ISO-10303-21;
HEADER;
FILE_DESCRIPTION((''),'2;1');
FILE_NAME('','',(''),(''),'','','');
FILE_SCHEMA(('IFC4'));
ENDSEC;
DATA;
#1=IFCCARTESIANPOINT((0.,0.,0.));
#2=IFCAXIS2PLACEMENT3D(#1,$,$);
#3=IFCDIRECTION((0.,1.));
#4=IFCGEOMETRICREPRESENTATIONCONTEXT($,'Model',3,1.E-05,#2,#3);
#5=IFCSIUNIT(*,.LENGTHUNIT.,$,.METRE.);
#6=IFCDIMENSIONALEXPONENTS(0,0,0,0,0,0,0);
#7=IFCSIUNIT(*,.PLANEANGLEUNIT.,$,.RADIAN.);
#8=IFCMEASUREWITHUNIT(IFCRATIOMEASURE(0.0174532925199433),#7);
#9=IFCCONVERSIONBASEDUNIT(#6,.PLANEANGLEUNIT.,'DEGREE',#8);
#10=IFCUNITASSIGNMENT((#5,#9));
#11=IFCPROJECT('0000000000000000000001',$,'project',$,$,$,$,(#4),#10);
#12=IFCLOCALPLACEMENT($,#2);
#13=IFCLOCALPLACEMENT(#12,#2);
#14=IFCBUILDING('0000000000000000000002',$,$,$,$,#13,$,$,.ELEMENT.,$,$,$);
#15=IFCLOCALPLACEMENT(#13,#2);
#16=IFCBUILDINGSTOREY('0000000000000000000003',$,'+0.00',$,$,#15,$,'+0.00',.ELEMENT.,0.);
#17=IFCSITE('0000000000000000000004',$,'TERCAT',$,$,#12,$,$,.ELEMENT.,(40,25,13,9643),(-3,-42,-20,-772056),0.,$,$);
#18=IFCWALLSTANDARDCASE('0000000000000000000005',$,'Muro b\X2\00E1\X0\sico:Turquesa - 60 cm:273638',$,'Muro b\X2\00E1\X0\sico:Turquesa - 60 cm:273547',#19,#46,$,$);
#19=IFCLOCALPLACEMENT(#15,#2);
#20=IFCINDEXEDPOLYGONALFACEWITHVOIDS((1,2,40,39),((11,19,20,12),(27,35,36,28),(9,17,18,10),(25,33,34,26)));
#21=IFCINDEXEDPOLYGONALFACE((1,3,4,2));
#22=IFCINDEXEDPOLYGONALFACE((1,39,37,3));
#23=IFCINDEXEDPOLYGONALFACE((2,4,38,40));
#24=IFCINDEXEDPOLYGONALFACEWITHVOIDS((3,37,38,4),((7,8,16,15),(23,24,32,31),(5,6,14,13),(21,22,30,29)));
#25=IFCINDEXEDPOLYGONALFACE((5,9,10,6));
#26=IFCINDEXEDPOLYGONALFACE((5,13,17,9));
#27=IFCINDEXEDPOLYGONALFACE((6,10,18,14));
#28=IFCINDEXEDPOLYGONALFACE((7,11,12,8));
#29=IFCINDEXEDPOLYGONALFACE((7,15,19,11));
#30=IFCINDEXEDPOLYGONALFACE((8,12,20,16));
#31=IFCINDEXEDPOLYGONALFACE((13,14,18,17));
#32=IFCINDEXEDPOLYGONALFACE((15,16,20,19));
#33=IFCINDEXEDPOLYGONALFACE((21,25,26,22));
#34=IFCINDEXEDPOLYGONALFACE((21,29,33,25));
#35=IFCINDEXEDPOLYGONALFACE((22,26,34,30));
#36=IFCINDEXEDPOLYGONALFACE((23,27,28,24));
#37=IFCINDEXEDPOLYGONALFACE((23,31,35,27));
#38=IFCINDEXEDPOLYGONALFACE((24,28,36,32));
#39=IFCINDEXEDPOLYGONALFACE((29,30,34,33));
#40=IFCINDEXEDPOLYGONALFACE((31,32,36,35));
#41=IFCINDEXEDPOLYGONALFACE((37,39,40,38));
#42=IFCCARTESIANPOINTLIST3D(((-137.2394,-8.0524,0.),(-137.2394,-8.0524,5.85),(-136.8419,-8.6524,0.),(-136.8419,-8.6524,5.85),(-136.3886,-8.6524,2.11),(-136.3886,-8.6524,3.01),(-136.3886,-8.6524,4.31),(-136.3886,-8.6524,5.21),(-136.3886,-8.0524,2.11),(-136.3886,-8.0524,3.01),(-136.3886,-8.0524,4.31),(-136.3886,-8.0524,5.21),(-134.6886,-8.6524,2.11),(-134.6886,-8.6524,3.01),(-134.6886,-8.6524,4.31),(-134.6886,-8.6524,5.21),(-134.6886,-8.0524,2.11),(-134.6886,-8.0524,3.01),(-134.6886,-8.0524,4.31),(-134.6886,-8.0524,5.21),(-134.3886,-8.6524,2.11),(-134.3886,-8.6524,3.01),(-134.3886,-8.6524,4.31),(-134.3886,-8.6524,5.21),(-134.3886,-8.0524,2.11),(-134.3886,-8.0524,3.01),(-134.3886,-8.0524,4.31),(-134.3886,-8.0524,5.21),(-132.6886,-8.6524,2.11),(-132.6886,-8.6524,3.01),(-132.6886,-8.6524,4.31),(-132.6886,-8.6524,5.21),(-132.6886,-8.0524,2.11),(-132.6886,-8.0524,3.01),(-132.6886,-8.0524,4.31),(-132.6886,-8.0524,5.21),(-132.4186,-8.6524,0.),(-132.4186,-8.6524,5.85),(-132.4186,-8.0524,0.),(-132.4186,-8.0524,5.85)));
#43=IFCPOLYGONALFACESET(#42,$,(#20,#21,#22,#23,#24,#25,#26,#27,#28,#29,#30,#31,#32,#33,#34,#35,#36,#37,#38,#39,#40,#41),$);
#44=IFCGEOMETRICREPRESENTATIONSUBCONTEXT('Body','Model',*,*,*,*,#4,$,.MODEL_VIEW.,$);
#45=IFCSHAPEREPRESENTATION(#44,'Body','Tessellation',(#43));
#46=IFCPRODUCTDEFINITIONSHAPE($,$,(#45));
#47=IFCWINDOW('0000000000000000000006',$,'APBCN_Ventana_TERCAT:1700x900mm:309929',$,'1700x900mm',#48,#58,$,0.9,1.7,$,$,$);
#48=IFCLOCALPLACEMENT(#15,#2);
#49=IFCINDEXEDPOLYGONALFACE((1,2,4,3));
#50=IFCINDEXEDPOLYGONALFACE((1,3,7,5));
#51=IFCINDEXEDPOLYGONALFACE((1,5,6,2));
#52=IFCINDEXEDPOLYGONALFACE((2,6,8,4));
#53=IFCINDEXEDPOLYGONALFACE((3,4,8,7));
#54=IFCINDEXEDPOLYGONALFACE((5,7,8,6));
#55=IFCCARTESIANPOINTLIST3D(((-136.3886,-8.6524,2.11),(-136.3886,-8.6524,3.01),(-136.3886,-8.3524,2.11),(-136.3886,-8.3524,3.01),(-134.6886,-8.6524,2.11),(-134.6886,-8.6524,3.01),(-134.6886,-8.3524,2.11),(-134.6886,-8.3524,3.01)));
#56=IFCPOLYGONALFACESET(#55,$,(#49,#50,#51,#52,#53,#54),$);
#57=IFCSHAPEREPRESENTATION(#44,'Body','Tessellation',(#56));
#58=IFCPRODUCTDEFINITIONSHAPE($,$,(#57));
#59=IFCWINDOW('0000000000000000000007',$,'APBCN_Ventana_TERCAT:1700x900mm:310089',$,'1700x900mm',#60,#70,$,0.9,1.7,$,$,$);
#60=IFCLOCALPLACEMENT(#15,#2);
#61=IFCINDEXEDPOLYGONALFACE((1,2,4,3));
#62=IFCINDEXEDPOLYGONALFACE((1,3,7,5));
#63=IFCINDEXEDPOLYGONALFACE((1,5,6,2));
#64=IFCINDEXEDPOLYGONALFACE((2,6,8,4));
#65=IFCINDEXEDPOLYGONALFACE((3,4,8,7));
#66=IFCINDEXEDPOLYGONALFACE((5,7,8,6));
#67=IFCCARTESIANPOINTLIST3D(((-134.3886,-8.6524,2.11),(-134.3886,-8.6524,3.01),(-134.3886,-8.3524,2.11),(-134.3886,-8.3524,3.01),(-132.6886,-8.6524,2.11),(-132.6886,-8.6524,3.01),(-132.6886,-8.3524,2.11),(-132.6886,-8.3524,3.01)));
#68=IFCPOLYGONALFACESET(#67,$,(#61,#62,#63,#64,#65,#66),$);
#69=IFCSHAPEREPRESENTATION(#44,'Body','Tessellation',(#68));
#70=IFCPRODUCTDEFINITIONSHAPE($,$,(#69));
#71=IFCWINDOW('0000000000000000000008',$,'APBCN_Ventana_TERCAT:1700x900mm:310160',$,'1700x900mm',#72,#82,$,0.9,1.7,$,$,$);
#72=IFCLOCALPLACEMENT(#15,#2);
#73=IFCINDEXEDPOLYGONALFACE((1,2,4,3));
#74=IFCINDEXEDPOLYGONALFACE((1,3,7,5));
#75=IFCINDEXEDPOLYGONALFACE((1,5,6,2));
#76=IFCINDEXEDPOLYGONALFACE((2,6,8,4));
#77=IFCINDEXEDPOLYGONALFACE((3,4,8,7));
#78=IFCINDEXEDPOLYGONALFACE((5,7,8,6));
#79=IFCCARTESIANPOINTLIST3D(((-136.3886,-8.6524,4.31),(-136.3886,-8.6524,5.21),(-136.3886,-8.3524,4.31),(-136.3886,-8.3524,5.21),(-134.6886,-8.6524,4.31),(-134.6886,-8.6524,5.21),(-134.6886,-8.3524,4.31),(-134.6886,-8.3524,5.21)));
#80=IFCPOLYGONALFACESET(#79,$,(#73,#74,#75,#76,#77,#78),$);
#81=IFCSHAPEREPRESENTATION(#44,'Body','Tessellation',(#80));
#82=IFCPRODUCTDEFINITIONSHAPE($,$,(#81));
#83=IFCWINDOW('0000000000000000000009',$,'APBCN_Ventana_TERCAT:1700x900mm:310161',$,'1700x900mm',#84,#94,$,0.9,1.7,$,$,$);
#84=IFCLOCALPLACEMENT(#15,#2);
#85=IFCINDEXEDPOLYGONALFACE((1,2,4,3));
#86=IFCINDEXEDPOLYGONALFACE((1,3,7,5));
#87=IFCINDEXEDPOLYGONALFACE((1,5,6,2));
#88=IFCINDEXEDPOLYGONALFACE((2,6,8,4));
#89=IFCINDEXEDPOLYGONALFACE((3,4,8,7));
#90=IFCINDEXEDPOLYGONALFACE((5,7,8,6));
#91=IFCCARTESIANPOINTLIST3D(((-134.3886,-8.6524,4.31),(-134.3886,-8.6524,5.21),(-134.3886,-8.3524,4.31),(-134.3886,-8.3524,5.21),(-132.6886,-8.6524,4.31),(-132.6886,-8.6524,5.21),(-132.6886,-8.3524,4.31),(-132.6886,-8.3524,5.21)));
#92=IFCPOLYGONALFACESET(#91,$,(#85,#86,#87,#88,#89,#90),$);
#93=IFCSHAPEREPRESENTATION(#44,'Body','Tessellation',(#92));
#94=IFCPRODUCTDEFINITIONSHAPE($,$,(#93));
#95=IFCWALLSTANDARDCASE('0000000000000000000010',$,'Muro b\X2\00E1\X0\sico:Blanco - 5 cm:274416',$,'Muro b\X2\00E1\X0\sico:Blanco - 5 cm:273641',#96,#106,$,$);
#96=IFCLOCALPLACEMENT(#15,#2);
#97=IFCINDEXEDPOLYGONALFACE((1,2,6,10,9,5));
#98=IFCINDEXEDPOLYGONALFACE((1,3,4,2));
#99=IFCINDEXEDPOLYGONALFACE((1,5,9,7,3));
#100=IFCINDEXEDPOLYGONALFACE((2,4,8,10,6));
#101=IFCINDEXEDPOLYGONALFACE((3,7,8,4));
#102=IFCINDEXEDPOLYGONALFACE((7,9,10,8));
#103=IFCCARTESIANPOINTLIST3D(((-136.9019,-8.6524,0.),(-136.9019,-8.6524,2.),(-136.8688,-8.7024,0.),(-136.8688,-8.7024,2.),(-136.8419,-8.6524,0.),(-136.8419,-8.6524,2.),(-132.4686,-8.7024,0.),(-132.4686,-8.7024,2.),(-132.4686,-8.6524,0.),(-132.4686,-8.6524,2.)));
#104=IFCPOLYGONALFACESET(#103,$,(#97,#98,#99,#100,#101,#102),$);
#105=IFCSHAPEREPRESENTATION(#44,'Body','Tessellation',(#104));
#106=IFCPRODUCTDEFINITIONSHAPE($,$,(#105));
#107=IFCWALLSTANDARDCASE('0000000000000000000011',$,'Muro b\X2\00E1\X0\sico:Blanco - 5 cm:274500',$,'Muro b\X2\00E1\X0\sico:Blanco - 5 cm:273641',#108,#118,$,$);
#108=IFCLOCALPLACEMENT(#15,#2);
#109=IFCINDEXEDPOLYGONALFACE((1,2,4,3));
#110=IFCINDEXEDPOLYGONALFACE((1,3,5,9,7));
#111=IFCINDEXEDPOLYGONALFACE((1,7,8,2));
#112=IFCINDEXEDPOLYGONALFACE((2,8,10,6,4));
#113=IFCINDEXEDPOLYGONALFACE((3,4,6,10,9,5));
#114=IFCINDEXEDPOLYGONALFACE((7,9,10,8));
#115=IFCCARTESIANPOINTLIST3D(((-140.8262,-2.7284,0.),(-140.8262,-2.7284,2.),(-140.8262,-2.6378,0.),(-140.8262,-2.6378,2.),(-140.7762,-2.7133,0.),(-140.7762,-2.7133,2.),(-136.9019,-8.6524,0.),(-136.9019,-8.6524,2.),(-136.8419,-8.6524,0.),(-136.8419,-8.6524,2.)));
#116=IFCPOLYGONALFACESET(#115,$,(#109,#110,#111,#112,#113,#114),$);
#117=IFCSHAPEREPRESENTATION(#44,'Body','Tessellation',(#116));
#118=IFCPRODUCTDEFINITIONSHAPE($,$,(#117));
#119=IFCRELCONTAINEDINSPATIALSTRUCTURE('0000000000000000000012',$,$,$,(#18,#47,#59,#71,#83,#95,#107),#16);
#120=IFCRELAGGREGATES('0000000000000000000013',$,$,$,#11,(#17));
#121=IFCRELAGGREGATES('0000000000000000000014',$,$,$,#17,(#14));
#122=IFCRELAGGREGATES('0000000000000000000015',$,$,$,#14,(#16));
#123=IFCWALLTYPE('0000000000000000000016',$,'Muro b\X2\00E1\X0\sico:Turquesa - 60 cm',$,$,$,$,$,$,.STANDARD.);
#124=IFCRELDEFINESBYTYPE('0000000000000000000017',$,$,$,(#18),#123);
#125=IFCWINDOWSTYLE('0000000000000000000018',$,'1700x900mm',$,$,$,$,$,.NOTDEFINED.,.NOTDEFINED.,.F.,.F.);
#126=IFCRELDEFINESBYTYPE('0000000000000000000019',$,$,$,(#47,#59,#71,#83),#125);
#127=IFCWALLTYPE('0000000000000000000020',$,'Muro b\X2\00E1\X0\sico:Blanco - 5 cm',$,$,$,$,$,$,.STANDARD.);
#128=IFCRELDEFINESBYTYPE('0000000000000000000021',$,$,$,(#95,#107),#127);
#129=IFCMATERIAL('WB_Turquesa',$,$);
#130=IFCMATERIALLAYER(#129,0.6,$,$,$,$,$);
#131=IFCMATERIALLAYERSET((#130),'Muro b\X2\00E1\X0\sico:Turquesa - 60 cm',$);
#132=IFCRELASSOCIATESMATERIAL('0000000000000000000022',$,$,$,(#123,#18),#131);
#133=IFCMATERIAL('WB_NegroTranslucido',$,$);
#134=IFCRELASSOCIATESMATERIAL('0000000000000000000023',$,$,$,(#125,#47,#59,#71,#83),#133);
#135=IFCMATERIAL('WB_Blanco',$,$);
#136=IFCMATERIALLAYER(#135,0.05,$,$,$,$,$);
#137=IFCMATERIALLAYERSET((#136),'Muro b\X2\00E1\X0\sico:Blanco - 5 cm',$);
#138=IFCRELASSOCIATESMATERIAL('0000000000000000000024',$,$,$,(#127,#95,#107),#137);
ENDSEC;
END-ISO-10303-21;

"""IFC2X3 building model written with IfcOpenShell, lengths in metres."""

from ifc_helpers import new_model, entity, si_unit, converted_unit, direction, frame, frame_2d, origin, place, context, subcontext, project, spatial, polyline, rectangle, outline, extrude, clip, bounded_halfspace, source, transform, mapped, material, layer, layer_set, layer_usage, type_object, type_shapes, element, fill, save


model = new_model("IFC2X3")

# Units and contexts
model_context = context("Model", 3, precision=1e-05, world=origin(), true_north=direction((0.0, 1.0)))
body_context = subcontext(model_context, "Body", "Model", "MODEL_VIEW")
ifc_project = project(units=[si_unit("LENGTHUNIT", "METRE"), converted_unit("PLANEANGLEUNIT", "DEGREE", entity("IfcRatioMeasure", 0.0174532925199433), si_unit("PLANEANGLEUNIT", "RADIAN"), dimensions=[0, 0, 0, 0, 0, 0, 0])], contexts=[model_context])

# Site, building, storey
site_placement = place(None, origin())
site = spatial("IfcSite", under=ifc_project, at=site_placement, Name="TERCAT", CompositionType="ELEMENT", RefLatitude=(40, 25, 13, 9643), RefLongitude=(-3, -42, -20, -772056), RefElevation=0.0)
building_placement = place(site_placement, origin())
building = spatial("IfcBuilding", under=site, at=building_placement, CompositionType="ELEMENT")
storey_placement = place(building_placement, origin())
storey = spatial("IfcBuildingStorey", under=building, at=storey_placement, Name="+0.00", LongName="+0.00", CompositionType="ELEMENT", Elevation=0.0)

# Wall, openings, windows
ifc_material_1 = material(Name="WB_Turquesa")
ifc_layer_1 = layer(ifc_material_1, 0.6)
ifc_layer_set_1 = layer_set([ifc_layer_1], Name="Muro básico:Turquesa - 60 cm")
ifc_layer_usage_1 = layer_usage(ifc_layer_set_1, "AXIS2", "POSITIVE", -0.3)
wall_type_1 = type_object("IfcWallType", Name="Muro básico:Turquesa - 60 cm", PredefinedType="STANDARD", material=ifc_layer_set_1)
wall_1_placement = place(storey_placement, frame((-137.2394, -8.3524, 0.0)))
wall_1 = element("IfcWallStandardCase", 1, at=wall_1_placement, inside=storey, type_object=wall_type_1, material=ifc_layer_usage_1, Name="Muro básico:Turquesa - 60 cm:273638", ObjectType="Muro básico:Turquesa - 60 cm:273547", context=body_context, shape_type="Clipping", body=[
    clip(extrude(outline(polyline([(4.8208, -0.3), (4.8208, 0.3), (0.7197, 0.3), (0.0, 0.3), (0.3975, -0.3), (4.8208, -0.3)])), origin(), (0.0, 0.0, 1.0), 5.85), bounded_halfspace(frame((0.3975, -0.3, 5.85)), False, frame((0.3975, -0.3, 5.85)), polyline([(0.0, 0.0), (4.4233, 0.0), (4.4233, 0.6), (0.3222, 0.6), (-0.3975, 0.6), (0.0, 0.0)]))),
])
opening_1_placement = place(wall_1_placement, frame((0.8508, -0.3, 2.11)))
opening_1 = element("IfcOpeningElement", 2, at=opening_1_placement, cuts=wall_1, ObjectType="Opening", context=body_context, shape_type="SweptSolid", body=[
    extrude(rectangle(XDim=0.9, YDim=1.7, at=frame_2d((0.45, 0.85), x_axis=(1.0, 0.0))), frame((0.0, 0.0, 0.0), z_axis=(0.0, 1.0, 0.0), x_axis=(0.0, 0.0, 1.0)), (0.0, 0.0, 1.0), 0.6),
])
opening_2_placement = place(wall_1_placement, frame((2.8508, -0.3, 2.11)))
opening_2 = element("IfcOpeningElement", 3, at=opening_2_placement, cuts=wall_1, ObjectType="Opening", context=body_context, shape_type="SweptSolid", body=[
    extrude(rectangle(XDim=0.9, YDim=1.7, at=frame_2d((0.45, 0.85), x_axis=(1.0, 0.0))), frame((0.0, 0.0, 0.0), z_axis=(0.0, 1.0, 0.0), x_axis=(0.0, 0.0, 1.0)), (0.0, 0.0, 1.0), 0.6),
])
opening_3_placement = place(wall_1_placement, frame((0.8508, -0.3, 4.31)))
opening_3 = element("IfcOpeningElement", 4, at=opening_3_placement, cuts=wall_1, ObjectType="Opening", context=body_context, shape_type="SweptSolid", body=[
    extrude(rectangle(XDim=0.9, YDim=1.7, at=frame_2d((0.45, 0.85), x_axis=(1.0, 0.0))), frame((0.0, 0.0, 0.0), z_axis=(0.0, 1.0, 0.0), x_axis=(0.0, 0.0, 1.0)), (0.0, 0.0, 1.0), 0.6),
])
opening_4_placement = place(wall_1_placement, frame((2.8508, -0.3, 4.31)))
opening_4 = element("IfcOpeningElement", 5, at=opening_4_placement, cuts=wall_1, ObjectType="Opening", context=body_context, shape_type="SweptSolid", body=[
    extrude(rectangle(XDim=0.9, YDim=1.7, at=frame_2d((0.45, 0.85), x_axis=(1.0, 0.0))), frame((0.0, 0.0, 0.0), z_axis=(0.0, 1.0, 0.0), x_axis=(0.0, 0.0, 1.0)), (0.0, 0.0, 1.0), 0.6),
])
ifc_material_2 = material(Name="WB_NegroTranslucido")
window_style = type_object("IfcWindowStyle", Name="1700x900mm", ConstructionType="NOTDEFINED", OperationType="NOTDEFINED", ParameterTakesPrecedence=False, Sizeable=False, material=ifc_material_2)
shared_shape = source(origin(), body_context, "Body", "SweptSolid", [
    extrude(rectangle(XDim=0.3, YDim=1.7, at=frame_2d((0.0, 0.0), x_axis=(1.0, 0.0))), frame((0.85, 0.15, 0.0), z_axis=(0.0, 0.0, 1.0), x_axis=(0.0, 1.0, 0.0)), (0.0, 0.0, 1.0), 0.9),
])
type_shapes(window_style, [shared_shape])
window_1_placement = place(opening_1_placement, origin())
window_1 = element("IfcWindow", 6, at=window_1_placement, inside=storey, type_object=window_style, material=ifc_material_2, Name="APBCN_Ventana_TERCAT:1700x900mm:309929", ObjectType="1700x900mm", OverallHeight=0.9, OverallWidth=1.7, context=body_context, shape_type="MappedRepresentation", body=[
    mapped(shared_shape, transform((0.0, 0.0, 0.0), scale=1.0)),
])
fill(opening_1, window_1)
window_2_placement = place(opening_2_placement, origin())
window_2 = element("IfcWindow", 7, at=window_2_placement, inside=storey, type_object=window_style, material=ifc_material_2, Name="APBCN_Ventana_TERCAT:1700x900mm:310089", ObjectType="1700x900mm", OverallHeight=0.9, OverallWidth=1.7, context=body_context, shape_type="MappedRepresentation", body=[
    mapped(shared_shape, transform((0.0, 0.0, 0.0), scale=1.0)),
])
fill(opening_2, window_2)
window_3_placement = place(opening_3_placement, origin())
window_3 = element("IfcWindow", 8, at=window_3_placement, inside=storey, type_object=window_style, material=ifc_material_2, Name="APBCN_Ventana_TERCAT:1700x900mm:310160", ObjectType="1700x900mm", OverallHeight=0.9, OverallWidth=1.7, context=body_context, shape_type="MappedRepresentation", body=[
    mapped(shared_shape, transform((0.0, 0.0, 0.0), scale=1.0)),
])
fill(opening_3, window_3)
window_4_placement = place(opening_4_placement, origin())
window_4 = element("IfcWindow", 9, at=window_4_placement, inside=storey, type_object=window_style, material=ifc_material_2, Name="APBCN_Ventana_TERCAT:1700x900mm:310161", ObjectType="1700x900mm", OverallHeight=0.9, OverallWidth=1.7, context=body_context, shape_type="MappedRepresentation", body=[
    mapped(shared_shape, transform((0.0, 0.0, 0.0), scale=1.0)),
])
fill(opening_4, window_4)

# Walls
ifc_material_3 = material(Name="WB_Blanco")
ifc_layer_2 = layer(ifc_material_3, 0.05)
ifc_layer_set_2 = layer_set([ifc_layer_2], Name="Muro básico:Blanco - 5 cm")
ifc_layer_usage_2 = layer_usage(ifc_layer_set_2, "AXIS2", "POSITIVE", -0.025)
wall_type_2 = type_object("IfcWallType", Name="Muro básico:Blanco - 5 cm", PredefinedType="STANDARD", material=ifc_layer_set_2)
wall_2_placement = place(storey_placement, frame((-132.4686, -8.6774, 0.0), z_axis=(0.0, 0.0, 1.0), x_axis=(-1.0, 0.0, 0.0)))
element("IfcWallStandardCase", 10, at=wall_2_placement, inside=storey, type_object=wall_type_2, material=ifc_layer_usage_2, Name="Muro básico:Blanco - 5 cm:274416", ObjectType="Muro básico:Blanco - 5 cm:273641", context=body_context, shape_type="SweptSolid", body=[
    extrude(outline(polyline([(4.4333, -0.025), (4.4002, 0.025), (0.0, 0.025), (0.0, -0.025), (4.3733, -0.025), (4.4333, -0.025)])), origin(), (0.0, 0.0, 1.0), 2.0),
])
ifc_layer_usage_3 = layer_usage(ifc_layer_set_2, "AXIS2", "POSITIVE", -0.025)
wall_3_placement = place(storey_placement, frame((-136.8627, -8.6662, 0.0), z_axis=(0.0, 0.0, 1.0), x_axis=(-0.552261, 0.833671, 0.0)))
element("IfcWallStandardCase", 11, at=wall_3_placement, inside=storey, type_object=wall_type_2, material=ifc_layer_usage_3, Name="Muro básico:Blanco - 5 cm:274500", ObjectType="Muro básico:Blanco - 5 cm:273641", context=body_context, shape_type="SweptSolid", body=[
    extrude(outline(polyline([(7.2145, -0.025), (7.139, 0.025), (0.0331, 0.025), (0.0, -0.025), (7.124, -0.025), (7.2145, -0.025)])), origin(), (0.0, 0.0, 1.0), 2.0),
])

save(model, "model.ifc")
